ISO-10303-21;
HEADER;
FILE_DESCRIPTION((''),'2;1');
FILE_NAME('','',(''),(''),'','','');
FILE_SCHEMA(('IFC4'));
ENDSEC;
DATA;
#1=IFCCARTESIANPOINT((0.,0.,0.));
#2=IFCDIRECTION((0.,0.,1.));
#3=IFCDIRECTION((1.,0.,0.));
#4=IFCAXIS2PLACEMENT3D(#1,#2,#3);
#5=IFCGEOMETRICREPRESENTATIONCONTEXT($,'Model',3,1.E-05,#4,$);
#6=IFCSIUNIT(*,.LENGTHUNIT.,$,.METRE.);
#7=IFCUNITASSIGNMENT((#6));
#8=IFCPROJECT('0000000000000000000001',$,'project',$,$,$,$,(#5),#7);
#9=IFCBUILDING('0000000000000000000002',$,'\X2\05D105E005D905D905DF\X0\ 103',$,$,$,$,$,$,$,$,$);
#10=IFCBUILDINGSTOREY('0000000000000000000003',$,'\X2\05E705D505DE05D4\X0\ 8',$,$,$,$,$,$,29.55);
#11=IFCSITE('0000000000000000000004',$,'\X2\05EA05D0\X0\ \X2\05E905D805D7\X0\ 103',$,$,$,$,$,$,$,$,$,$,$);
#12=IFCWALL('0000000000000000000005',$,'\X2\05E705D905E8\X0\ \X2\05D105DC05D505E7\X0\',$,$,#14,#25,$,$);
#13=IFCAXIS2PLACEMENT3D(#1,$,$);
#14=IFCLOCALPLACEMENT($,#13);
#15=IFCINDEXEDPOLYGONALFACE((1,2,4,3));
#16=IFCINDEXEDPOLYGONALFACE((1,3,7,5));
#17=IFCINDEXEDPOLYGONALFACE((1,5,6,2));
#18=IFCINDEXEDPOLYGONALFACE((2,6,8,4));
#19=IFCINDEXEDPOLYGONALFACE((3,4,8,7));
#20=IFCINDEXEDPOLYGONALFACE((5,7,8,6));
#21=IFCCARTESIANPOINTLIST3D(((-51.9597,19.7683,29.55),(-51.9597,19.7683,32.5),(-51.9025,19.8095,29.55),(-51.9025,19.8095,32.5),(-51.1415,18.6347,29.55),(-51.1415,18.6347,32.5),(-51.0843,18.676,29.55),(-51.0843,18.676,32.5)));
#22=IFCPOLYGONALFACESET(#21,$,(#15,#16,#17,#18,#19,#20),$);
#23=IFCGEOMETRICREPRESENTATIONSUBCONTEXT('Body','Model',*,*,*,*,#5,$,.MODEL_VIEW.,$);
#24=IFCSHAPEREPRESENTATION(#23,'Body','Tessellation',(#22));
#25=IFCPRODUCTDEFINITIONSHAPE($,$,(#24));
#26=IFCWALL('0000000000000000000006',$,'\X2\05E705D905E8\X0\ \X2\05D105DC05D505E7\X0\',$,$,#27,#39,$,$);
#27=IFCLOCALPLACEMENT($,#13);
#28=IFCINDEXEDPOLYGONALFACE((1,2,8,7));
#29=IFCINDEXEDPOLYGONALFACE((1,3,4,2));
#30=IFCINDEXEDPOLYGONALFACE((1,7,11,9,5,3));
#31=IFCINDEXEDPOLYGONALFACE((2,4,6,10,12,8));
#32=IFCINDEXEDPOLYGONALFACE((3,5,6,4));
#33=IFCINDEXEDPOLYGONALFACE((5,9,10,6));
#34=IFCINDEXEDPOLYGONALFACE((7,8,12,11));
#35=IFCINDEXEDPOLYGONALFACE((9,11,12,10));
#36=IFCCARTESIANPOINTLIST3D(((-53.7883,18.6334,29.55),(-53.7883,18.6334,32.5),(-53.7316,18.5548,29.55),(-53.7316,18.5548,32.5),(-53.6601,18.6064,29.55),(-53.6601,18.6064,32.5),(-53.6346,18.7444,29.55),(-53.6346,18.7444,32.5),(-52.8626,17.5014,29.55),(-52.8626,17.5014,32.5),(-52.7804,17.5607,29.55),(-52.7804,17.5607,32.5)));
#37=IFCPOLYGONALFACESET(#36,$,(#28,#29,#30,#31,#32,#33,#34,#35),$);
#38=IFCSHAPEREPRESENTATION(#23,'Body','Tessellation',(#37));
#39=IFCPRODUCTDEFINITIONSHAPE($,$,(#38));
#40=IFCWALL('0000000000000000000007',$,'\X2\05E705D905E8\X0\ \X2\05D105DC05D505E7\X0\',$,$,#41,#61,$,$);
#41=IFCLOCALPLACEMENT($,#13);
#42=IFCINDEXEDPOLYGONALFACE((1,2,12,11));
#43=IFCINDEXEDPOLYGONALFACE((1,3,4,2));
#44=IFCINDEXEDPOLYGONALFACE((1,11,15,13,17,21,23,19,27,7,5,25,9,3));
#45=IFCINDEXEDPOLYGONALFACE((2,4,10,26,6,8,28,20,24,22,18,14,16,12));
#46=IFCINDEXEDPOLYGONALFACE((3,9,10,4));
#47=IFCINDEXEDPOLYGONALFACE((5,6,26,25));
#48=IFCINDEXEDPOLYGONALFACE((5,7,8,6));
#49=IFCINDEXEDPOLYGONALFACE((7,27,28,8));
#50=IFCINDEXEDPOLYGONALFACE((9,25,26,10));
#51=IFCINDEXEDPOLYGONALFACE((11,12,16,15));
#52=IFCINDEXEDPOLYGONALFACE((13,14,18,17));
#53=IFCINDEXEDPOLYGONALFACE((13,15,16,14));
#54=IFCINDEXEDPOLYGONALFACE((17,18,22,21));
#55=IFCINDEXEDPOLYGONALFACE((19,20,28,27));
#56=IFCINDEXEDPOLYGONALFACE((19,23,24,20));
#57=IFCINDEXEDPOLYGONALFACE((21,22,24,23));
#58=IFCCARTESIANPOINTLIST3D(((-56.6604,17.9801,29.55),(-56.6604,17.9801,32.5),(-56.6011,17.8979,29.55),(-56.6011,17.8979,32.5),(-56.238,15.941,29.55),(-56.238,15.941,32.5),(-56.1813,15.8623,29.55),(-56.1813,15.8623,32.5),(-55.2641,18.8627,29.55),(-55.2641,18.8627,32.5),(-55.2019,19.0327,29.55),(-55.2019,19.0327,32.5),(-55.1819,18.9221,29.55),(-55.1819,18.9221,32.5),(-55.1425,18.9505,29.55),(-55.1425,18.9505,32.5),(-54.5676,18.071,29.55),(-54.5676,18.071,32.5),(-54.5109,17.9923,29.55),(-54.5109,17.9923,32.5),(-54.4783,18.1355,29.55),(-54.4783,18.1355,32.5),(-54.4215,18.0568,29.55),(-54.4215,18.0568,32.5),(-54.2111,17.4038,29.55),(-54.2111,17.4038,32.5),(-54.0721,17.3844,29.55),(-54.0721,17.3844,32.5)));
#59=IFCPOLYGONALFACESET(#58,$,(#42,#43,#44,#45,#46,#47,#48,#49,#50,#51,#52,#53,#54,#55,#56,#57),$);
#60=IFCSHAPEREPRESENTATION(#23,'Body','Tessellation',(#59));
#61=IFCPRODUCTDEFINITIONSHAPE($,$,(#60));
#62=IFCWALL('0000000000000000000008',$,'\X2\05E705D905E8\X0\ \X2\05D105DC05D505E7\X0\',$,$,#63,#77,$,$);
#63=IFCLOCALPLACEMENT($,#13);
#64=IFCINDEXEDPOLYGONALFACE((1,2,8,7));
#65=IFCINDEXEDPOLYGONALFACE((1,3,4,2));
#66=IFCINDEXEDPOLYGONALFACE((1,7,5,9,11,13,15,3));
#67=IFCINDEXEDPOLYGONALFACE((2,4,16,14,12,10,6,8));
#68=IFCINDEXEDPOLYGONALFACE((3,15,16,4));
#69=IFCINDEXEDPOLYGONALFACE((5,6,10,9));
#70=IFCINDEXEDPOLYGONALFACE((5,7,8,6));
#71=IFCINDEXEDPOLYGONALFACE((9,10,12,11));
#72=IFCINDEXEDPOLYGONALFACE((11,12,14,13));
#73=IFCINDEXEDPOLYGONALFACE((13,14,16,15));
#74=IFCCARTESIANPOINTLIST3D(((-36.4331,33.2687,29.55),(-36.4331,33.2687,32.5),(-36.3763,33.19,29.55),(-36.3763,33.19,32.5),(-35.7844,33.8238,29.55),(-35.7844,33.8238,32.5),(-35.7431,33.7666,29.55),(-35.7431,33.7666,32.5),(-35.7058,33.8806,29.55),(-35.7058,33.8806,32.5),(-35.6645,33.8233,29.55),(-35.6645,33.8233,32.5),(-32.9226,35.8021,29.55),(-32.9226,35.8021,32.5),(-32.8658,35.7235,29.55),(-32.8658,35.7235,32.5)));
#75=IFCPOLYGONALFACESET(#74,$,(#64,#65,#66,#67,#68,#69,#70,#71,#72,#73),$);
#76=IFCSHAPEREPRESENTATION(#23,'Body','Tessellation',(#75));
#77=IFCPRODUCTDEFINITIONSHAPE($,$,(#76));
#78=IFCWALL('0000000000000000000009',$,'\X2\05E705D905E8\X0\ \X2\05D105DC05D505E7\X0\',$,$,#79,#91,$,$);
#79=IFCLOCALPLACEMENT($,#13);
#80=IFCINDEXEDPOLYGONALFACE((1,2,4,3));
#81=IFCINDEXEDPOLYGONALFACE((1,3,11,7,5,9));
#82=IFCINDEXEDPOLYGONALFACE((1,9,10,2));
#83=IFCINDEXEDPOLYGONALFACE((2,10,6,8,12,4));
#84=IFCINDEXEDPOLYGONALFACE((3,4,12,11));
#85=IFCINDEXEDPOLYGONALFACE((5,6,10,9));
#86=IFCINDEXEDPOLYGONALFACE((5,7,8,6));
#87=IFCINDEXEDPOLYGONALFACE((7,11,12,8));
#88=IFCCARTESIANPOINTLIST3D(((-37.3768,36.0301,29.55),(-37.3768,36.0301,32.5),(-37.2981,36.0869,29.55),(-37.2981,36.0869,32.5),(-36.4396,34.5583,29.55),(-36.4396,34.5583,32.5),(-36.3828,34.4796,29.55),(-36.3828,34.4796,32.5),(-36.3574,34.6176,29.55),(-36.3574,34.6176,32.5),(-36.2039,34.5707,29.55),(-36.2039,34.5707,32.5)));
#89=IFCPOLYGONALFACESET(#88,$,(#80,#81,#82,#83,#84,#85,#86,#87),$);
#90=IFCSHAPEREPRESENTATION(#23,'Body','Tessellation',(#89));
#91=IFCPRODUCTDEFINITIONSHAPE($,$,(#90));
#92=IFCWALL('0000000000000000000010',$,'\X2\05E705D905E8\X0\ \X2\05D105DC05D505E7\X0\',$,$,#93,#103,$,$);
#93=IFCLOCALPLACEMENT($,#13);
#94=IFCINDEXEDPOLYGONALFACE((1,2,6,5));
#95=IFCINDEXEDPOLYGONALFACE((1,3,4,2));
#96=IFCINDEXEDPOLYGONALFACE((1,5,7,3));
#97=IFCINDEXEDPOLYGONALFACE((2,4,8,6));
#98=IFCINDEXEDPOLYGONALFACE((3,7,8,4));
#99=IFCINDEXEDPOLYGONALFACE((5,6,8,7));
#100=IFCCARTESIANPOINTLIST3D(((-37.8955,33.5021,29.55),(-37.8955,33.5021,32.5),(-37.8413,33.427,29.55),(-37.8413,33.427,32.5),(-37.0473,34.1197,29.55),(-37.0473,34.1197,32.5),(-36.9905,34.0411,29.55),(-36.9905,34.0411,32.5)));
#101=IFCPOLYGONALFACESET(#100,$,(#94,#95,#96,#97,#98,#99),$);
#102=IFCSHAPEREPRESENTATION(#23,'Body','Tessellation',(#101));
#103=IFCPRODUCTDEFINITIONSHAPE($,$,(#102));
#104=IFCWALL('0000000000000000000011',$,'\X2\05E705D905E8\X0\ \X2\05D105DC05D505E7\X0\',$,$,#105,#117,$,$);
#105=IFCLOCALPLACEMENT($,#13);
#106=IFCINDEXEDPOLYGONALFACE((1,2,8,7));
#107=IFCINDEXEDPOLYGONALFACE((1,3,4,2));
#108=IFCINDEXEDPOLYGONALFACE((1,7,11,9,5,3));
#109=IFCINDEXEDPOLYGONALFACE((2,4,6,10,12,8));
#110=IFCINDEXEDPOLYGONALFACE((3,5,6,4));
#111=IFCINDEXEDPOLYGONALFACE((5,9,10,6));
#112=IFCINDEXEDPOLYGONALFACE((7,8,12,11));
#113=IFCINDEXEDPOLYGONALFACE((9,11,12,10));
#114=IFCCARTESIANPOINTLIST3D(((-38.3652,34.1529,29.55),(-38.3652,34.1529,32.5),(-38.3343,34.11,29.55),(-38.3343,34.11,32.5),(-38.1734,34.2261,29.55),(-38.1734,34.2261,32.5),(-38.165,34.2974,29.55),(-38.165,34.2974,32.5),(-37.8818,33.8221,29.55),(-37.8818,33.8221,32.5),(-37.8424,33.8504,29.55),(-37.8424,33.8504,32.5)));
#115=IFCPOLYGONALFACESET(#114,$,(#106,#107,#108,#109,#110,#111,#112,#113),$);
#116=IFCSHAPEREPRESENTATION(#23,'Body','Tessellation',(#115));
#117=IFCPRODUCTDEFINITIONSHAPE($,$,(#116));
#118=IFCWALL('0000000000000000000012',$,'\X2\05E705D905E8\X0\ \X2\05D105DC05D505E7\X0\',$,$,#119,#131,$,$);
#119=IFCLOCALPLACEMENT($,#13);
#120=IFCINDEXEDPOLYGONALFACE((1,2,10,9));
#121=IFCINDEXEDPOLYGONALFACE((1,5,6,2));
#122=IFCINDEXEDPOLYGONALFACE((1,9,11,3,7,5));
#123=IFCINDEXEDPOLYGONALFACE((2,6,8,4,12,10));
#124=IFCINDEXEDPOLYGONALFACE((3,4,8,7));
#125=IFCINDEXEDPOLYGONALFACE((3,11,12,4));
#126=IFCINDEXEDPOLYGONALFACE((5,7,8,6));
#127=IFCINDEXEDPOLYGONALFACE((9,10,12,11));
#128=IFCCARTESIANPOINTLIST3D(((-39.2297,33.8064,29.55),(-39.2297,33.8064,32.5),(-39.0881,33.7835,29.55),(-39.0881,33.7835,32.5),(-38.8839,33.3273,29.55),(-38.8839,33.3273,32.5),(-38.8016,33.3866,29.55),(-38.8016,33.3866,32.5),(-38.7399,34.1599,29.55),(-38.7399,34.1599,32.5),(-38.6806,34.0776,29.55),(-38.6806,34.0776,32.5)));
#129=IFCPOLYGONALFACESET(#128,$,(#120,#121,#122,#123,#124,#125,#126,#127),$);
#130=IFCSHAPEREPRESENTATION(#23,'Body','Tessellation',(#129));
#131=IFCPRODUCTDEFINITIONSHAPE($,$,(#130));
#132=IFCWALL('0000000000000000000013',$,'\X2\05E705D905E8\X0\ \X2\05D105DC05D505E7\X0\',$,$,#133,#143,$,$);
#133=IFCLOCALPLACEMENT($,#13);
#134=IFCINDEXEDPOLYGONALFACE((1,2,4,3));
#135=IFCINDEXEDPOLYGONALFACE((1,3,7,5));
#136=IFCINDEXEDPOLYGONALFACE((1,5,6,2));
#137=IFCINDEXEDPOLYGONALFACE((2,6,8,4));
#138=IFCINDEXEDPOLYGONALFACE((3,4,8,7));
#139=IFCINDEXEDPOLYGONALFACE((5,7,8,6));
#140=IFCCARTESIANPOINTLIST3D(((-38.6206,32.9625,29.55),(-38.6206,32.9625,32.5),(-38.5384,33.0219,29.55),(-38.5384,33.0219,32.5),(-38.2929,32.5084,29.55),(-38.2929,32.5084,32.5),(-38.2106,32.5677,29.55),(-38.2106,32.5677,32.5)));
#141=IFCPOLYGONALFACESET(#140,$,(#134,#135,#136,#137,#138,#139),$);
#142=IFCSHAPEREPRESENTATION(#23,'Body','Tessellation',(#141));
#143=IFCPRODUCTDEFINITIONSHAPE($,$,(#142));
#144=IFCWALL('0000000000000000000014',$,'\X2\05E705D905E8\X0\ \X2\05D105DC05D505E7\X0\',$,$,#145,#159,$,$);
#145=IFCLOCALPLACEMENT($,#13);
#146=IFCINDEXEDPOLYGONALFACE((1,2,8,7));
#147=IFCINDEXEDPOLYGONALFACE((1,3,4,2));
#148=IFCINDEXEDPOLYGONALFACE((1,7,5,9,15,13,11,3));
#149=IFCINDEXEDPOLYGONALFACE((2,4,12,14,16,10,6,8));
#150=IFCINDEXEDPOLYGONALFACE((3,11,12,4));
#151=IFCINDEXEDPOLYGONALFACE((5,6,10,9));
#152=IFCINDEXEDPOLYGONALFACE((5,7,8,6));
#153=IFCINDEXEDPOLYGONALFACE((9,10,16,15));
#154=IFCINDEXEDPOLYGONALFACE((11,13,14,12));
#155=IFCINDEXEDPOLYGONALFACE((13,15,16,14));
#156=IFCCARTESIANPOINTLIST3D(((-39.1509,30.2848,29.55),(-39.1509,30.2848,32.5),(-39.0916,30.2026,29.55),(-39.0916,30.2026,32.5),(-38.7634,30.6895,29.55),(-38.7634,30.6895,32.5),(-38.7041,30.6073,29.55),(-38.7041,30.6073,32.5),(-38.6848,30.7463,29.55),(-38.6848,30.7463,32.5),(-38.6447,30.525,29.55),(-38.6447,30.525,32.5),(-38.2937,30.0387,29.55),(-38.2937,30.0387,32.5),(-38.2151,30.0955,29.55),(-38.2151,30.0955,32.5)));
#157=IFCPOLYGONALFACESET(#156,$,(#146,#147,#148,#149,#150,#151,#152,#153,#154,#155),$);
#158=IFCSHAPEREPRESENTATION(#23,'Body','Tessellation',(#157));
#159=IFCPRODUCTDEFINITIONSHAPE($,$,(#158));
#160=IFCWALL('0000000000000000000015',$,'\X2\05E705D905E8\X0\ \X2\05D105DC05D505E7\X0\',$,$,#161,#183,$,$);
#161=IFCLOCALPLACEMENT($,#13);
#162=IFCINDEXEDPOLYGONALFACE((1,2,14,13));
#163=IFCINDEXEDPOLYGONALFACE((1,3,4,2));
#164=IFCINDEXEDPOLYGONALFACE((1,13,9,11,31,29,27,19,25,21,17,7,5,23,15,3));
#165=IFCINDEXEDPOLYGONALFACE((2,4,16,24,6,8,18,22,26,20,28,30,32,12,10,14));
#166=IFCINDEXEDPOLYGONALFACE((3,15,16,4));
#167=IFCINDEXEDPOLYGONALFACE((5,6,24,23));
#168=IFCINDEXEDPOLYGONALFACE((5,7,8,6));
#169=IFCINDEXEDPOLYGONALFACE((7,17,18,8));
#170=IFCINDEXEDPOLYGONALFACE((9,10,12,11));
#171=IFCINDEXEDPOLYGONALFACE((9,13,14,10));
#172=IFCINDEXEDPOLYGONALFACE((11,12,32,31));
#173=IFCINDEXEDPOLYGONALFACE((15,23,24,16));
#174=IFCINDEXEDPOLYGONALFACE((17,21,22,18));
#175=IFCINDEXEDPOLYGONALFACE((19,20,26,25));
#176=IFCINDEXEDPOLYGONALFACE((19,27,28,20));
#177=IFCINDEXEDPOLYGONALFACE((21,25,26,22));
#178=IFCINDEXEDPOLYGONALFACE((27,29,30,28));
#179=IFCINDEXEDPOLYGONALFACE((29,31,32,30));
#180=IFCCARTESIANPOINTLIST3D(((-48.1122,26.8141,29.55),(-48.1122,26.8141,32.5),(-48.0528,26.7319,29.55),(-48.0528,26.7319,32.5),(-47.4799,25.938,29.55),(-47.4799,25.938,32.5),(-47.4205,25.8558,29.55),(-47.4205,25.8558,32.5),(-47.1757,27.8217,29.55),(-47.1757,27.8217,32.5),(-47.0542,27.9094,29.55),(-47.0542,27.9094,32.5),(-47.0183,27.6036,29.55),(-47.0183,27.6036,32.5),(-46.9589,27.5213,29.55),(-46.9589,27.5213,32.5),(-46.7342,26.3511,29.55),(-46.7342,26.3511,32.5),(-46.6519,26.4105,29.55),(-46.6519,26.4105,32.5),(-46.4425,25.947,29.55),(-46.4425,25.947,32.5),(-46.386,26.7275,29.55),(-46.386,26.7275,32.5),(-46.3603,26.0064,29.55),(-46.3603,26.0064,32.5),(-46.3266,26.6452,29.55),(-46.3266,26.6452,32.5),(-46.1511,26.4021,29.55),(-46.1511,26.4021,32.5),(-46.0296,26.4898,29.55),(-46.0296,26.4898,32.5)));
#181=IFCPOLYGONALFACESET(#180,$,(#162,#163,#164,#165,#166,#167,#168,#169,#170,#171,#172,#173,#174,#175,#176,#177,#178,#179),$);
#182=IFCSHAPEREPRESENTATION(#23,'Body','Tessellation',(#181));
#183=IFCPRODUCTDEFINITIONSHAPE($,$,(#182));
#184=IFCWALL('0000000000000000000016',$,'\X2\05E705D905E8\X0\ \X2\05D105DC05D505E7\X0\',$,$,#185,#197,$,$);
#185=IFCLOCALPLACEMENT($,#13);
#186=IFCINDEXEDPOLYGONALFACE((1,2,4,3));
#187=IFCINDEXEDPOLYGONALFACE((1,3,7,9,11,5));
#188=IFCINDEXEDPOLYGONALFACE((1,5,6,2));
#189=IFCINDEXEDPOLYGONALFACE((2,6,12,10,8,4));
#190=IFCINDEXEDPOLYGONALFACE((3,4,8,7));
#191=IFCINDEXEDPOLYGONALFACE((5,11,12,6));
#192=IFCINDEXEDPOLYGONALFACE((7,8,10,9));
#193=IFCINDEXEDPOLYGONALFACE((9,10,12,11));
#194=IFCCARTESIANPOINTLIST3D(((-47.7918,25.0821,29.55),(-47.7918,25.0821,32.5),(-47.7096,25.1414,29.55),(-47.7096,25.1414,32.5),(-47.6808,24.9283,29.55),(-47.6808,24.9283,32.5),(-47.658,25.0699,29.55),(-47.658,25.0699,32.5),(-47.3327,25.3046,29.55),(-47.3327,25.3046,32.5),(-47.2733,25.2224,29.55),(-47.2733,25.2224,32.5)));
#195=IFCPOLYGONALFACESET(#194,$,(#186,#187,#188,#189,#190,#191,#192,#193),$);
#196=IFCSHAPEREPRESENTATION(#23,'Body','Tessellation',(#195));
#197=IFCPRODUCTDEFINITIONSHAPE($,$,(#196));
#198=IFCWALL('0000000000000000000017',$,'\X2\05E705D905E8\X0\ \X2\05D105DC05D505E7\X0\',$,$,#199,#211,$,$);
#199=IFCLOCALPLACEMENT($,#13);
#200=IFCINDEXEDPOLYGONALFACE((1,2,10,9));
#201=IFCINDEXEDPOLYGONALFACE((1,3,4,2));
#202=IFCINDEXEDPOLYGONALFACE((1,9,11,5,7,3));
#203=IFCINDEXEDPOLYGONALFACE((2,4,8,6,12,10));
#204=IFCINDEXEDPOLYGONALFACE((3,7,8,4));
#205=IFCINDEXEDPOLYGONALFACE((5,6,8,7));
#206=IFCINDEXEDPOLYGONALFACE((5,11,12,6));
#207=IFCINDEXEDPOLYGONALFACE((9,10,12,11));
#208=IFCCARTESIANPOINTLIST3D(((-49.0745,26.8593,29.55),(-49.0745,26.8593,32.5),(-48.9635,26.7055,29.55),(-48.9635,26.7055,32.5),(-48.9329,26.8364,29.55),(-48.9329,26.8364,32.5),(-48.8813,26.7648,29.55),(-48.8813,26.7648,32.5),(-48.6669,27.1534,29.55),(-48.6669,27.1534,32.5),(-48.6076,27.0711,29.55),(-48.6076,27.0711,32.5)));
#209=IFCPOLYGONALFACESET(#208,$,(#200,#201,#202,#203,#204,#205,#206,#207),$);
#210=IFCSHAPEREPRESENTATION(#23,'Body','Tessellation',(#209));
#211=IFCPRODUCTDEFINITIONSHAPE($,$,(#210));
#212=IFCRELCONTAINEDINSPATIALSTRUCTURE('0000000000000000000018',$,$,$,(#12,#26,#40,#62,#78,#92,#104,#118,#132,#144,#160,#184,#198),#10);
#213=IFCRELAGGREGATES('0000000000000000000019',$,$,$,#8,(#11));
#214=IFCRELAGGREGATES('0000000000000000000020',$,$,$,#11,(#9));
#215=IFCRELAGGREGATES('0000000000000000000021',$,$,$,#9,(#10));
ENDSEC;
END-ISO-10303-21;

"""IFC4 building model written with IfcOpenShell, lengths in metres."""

from ifc_helpers import new_model, si_unit, frame, origin_with_axes, context, subcontext, project, spatial, polyline, outline, extrude, element, save


model = new_model("IFC4")

# Units and contexts
model_context = context("Model", 3, precision=1e-05, world=origin_with_axes())
body_context = subcontext(model_context, "Body", "Model", "MODEL_VIEW")
ifc_project = project(units=[si_unit("LENGTHUNIT", "METRE")], contexts=[model_context])

# Site, building, storey
site = spatial("IfcSite", under=ifc_project, Name="תא שטח 103")
building = spatial("IfcBuilding", under=site, Name="בניין 103")
storey = spatial("IfcBuildingStorey", under=building, Name="קומה 8", Elevation=29.55)

# Walls
element("IfcWall", 1, inside=storey, Name="קיר בלוק", context=body_context, shape_type="SweptSolid", body=[
    extrude(outline(polyline([(-51.9025, 19.8095), (-51.0843, 18.676), (-51.1415, 18.6347), (-51.9597, 19.7683), (-51.9025, 19.8095)])), frame((0.0, 0.0, 29.55)), (0.0, 0.0, 1.0), 2.95),
])
element("IfcWall", 2, inside=storey, Name="קיר בלוק", context=body_context, shape_type="SweptSolid", body=[
    extrude(outline(polyline([(-52.8626, 17.5014), (-53.6601, 18.6064), (-53.7316, 18.5548), (-53.7883, 18.6334), (-53.6346, 18.7444), (-52.7804, 17.5607), (-52.8626, 17.5014)])), frame((0.0, 0.0, 29.55)), (0.0, 0.0, 1.0), 2.95),
])
element("IfcWall", 3, inside=storey, Name="קיר בלוק", context=body_context, shape_type="SweptSolid", body=[
    extrude(outline(polyline([(-54.2111, 17.4038), (-55.2641, 18.8627), (-56.6011, 17.8979), (-56.6604, 17.9801), (-55.2019, 19.0327), (-55.1425, 18.9505), (-55.1819, 18.9221), (-54.5676, 18.071), (-54.4783, 18.1355), (-54.4215, 18.0568), (-54.5109, 17.9923), (-54.0721, 17.3844), (-56.1813, 15.8623), (-56.238, 15.941), (-54.2111, 17.4038)])), frame((0.0, 0.0, 29.55)), (0.0, 0.0, 1.0), 2.95),
])
element("IfcWall", 4, inside=storey, Name="קיר בלוק", context=body_context, shape_type="SweptSolid", body=[
    extrude(outline(polyline([(-32.8658, 35.7235), (-36.3763, 33.19), (-36.4331, 33.2687), (-35.7431, 33.7666), (-35.7844, 33.8238), (-35.7058, 33.8806), (-35.6645, 33.8233), (-32.9226, 35.8021), (-32.8658, 35.7235)])), frame((0.0, 0.0, 29.55)), (0.0, 0.0, 1.0), 2.95),
])
element("IfcWall", 5, inside=storey, Name="קיר בלוק", context=body_context, shape_type="SweptSolid", body=[
    extrude(outline(polyline([(-36.3828, 34.4796), (-36.4396, 34.5583), (-36.3574, 34.6176), (-37.3768, 36.0301), (-37.2981, 36.0869), (-36.2039, 34.5707), (-36.3828, 34.4796)])), frame((0.0, 0.0, 29.55)), (0.0, 0.0, 1.0), 2.95),
])
element("IfcWall", 6, inside=storey, Name="קיר בלוק", context=body_context, shape_type="SweptSolid", body=[
    extrude(outline(polyline([(-37.8413, 33.427), (-37.8955, 33.5021), (-37.0473, 34.1197), (-36.9905, 34.0411), (-37.8413, 33.427)])), frame((0.0, 0.0, 29.55)), (0.0, 0.0, 1.0), 2.95),
])
element("IfcWall", 7, inside=storey, Name="קיר בלוק", context=body_context, shape_type="SweptSolid", body=[
    extrude(outline(polyline([(-37.8818, 33.8221), (-38.1734, 34.2261), (-38.3343, 34.11), (-38.3652, 34.1529), (-38.165, 34.2974), (-37.8424, 33.8504), (-37.8818, 33.8221)])), frame((0.0, 0.0, 29.55)), (0.0, 0.0, 1.0), 2.95),
])
element("IfcWall", 8, inside=storey, Name="קיר בלוק", context=body_context, shape_type="SweptSolid", body=[
    extrude(outline(polyline([(-38.8016, 33.3866), (-38.8839, 33.3273), (-39.2297, 33.8064), (-38.7399, 34.1599), (-38.6806, 34.0776), (-39.0881, 33.7835), (-38.8016, 33.3866)])), frame((0.0, 0.0, 29.55)), (0.0, 0.0, 1.0), 2.95),
])
element("IfcWall", 9, inside=storey, Name="קיר בלוק", context=body_context, shape_type="SweptSolid", body=[
    extrude(outline(polyline([(-38.2106, 32.5677), (-38.2929, 32.5084), (-38.6206, 32.9625), (-38.5384, 33.0219), (-38.2106, 32.5677)])), frame((0.0, 0.0, 29.55)), (0.0, 0.0, 1.0), 2.95),
])
element("IfcWall", 10, inside=storey, Name="קיר בלוק", context=body_context, shape_type="SweptSolid", body=[
    extrude(outline(polyline([(-38.7041, 30.6073), (-38.7634, 30.6895), (-38.6848, 30.7463), (-38.2151, 30.0955), (-38.2937, 30.0387), (-38.6447, 30.525), (-39.0916, 30.2026), (-39.1509, 30.2848), (-38.7041, 30.6073)])), frame((0.0, 0.0, 29.55)), (0.0, 0.0, 1.0), 2.95),
])
element("IfcWall", 11, inside=storey, Name="קיר בלוק", context=body_context, shape_type="SweptSolid", body=[
    extrude(outline(polyline([(-46.3603, 26.0064), (-46.4425, 25.947), (-46.7342, 26.3511), (-47.4205, 25.8558), (-47.4799, 25.938), (-46.386, 26.7275), (-46.9589, 27.5213), (-48.0528, 26.7319), (-48.1122, 26.8141), (-47.0183, 27.6036), (-47.1757, 27.8217), (-47.0542, 27.9094), (-46.0296, 26.4898), (-46.1511, 26.4021), (-46.3266, 26.6452), (-46.6519, 26.4105), (-46.3603, 26.0064)])), frame((0.0, 0.0, 29.55)), (0.0, 0.0, 1.0), 2.95),
])
element("IfcWall", 12, inside=storey, Name="קיר בלוק", context=body_context, shape_type="SweptSolid", body=[
    extrude(outline(polyline([(-47.7096, 25.1414), (-47.658, 25.0699), (-47.3327, 25.3046), (-47.2733, 25.2224), (-47.6808, 24.9283), (-47.7918, 25.0821), (-47.7096, 25.1414)])), frame((0.0, 0.0, 29.55)), (0.0, 0.0, 1.0), 2.95),
])
element("IfcWall", 13, inside=storey, Name="קיר בלוק", context=body_context, shape_type="SweptSolid", body=[
    extrude(outline(polyline([(-49.0745, 26.8593), (-48.6669, 27.1534), (-48.6076, 27.0711), (-48.9329, 26.8364), (-48.8813, 26.7648), (-48.9635, 26.7055), (-49.0745, 26.8593)])), frame((0.0, 0.0, 29.55)), (0.0, 0.0, 1.0), 2.95),
])

save(model, "model.ifc")
